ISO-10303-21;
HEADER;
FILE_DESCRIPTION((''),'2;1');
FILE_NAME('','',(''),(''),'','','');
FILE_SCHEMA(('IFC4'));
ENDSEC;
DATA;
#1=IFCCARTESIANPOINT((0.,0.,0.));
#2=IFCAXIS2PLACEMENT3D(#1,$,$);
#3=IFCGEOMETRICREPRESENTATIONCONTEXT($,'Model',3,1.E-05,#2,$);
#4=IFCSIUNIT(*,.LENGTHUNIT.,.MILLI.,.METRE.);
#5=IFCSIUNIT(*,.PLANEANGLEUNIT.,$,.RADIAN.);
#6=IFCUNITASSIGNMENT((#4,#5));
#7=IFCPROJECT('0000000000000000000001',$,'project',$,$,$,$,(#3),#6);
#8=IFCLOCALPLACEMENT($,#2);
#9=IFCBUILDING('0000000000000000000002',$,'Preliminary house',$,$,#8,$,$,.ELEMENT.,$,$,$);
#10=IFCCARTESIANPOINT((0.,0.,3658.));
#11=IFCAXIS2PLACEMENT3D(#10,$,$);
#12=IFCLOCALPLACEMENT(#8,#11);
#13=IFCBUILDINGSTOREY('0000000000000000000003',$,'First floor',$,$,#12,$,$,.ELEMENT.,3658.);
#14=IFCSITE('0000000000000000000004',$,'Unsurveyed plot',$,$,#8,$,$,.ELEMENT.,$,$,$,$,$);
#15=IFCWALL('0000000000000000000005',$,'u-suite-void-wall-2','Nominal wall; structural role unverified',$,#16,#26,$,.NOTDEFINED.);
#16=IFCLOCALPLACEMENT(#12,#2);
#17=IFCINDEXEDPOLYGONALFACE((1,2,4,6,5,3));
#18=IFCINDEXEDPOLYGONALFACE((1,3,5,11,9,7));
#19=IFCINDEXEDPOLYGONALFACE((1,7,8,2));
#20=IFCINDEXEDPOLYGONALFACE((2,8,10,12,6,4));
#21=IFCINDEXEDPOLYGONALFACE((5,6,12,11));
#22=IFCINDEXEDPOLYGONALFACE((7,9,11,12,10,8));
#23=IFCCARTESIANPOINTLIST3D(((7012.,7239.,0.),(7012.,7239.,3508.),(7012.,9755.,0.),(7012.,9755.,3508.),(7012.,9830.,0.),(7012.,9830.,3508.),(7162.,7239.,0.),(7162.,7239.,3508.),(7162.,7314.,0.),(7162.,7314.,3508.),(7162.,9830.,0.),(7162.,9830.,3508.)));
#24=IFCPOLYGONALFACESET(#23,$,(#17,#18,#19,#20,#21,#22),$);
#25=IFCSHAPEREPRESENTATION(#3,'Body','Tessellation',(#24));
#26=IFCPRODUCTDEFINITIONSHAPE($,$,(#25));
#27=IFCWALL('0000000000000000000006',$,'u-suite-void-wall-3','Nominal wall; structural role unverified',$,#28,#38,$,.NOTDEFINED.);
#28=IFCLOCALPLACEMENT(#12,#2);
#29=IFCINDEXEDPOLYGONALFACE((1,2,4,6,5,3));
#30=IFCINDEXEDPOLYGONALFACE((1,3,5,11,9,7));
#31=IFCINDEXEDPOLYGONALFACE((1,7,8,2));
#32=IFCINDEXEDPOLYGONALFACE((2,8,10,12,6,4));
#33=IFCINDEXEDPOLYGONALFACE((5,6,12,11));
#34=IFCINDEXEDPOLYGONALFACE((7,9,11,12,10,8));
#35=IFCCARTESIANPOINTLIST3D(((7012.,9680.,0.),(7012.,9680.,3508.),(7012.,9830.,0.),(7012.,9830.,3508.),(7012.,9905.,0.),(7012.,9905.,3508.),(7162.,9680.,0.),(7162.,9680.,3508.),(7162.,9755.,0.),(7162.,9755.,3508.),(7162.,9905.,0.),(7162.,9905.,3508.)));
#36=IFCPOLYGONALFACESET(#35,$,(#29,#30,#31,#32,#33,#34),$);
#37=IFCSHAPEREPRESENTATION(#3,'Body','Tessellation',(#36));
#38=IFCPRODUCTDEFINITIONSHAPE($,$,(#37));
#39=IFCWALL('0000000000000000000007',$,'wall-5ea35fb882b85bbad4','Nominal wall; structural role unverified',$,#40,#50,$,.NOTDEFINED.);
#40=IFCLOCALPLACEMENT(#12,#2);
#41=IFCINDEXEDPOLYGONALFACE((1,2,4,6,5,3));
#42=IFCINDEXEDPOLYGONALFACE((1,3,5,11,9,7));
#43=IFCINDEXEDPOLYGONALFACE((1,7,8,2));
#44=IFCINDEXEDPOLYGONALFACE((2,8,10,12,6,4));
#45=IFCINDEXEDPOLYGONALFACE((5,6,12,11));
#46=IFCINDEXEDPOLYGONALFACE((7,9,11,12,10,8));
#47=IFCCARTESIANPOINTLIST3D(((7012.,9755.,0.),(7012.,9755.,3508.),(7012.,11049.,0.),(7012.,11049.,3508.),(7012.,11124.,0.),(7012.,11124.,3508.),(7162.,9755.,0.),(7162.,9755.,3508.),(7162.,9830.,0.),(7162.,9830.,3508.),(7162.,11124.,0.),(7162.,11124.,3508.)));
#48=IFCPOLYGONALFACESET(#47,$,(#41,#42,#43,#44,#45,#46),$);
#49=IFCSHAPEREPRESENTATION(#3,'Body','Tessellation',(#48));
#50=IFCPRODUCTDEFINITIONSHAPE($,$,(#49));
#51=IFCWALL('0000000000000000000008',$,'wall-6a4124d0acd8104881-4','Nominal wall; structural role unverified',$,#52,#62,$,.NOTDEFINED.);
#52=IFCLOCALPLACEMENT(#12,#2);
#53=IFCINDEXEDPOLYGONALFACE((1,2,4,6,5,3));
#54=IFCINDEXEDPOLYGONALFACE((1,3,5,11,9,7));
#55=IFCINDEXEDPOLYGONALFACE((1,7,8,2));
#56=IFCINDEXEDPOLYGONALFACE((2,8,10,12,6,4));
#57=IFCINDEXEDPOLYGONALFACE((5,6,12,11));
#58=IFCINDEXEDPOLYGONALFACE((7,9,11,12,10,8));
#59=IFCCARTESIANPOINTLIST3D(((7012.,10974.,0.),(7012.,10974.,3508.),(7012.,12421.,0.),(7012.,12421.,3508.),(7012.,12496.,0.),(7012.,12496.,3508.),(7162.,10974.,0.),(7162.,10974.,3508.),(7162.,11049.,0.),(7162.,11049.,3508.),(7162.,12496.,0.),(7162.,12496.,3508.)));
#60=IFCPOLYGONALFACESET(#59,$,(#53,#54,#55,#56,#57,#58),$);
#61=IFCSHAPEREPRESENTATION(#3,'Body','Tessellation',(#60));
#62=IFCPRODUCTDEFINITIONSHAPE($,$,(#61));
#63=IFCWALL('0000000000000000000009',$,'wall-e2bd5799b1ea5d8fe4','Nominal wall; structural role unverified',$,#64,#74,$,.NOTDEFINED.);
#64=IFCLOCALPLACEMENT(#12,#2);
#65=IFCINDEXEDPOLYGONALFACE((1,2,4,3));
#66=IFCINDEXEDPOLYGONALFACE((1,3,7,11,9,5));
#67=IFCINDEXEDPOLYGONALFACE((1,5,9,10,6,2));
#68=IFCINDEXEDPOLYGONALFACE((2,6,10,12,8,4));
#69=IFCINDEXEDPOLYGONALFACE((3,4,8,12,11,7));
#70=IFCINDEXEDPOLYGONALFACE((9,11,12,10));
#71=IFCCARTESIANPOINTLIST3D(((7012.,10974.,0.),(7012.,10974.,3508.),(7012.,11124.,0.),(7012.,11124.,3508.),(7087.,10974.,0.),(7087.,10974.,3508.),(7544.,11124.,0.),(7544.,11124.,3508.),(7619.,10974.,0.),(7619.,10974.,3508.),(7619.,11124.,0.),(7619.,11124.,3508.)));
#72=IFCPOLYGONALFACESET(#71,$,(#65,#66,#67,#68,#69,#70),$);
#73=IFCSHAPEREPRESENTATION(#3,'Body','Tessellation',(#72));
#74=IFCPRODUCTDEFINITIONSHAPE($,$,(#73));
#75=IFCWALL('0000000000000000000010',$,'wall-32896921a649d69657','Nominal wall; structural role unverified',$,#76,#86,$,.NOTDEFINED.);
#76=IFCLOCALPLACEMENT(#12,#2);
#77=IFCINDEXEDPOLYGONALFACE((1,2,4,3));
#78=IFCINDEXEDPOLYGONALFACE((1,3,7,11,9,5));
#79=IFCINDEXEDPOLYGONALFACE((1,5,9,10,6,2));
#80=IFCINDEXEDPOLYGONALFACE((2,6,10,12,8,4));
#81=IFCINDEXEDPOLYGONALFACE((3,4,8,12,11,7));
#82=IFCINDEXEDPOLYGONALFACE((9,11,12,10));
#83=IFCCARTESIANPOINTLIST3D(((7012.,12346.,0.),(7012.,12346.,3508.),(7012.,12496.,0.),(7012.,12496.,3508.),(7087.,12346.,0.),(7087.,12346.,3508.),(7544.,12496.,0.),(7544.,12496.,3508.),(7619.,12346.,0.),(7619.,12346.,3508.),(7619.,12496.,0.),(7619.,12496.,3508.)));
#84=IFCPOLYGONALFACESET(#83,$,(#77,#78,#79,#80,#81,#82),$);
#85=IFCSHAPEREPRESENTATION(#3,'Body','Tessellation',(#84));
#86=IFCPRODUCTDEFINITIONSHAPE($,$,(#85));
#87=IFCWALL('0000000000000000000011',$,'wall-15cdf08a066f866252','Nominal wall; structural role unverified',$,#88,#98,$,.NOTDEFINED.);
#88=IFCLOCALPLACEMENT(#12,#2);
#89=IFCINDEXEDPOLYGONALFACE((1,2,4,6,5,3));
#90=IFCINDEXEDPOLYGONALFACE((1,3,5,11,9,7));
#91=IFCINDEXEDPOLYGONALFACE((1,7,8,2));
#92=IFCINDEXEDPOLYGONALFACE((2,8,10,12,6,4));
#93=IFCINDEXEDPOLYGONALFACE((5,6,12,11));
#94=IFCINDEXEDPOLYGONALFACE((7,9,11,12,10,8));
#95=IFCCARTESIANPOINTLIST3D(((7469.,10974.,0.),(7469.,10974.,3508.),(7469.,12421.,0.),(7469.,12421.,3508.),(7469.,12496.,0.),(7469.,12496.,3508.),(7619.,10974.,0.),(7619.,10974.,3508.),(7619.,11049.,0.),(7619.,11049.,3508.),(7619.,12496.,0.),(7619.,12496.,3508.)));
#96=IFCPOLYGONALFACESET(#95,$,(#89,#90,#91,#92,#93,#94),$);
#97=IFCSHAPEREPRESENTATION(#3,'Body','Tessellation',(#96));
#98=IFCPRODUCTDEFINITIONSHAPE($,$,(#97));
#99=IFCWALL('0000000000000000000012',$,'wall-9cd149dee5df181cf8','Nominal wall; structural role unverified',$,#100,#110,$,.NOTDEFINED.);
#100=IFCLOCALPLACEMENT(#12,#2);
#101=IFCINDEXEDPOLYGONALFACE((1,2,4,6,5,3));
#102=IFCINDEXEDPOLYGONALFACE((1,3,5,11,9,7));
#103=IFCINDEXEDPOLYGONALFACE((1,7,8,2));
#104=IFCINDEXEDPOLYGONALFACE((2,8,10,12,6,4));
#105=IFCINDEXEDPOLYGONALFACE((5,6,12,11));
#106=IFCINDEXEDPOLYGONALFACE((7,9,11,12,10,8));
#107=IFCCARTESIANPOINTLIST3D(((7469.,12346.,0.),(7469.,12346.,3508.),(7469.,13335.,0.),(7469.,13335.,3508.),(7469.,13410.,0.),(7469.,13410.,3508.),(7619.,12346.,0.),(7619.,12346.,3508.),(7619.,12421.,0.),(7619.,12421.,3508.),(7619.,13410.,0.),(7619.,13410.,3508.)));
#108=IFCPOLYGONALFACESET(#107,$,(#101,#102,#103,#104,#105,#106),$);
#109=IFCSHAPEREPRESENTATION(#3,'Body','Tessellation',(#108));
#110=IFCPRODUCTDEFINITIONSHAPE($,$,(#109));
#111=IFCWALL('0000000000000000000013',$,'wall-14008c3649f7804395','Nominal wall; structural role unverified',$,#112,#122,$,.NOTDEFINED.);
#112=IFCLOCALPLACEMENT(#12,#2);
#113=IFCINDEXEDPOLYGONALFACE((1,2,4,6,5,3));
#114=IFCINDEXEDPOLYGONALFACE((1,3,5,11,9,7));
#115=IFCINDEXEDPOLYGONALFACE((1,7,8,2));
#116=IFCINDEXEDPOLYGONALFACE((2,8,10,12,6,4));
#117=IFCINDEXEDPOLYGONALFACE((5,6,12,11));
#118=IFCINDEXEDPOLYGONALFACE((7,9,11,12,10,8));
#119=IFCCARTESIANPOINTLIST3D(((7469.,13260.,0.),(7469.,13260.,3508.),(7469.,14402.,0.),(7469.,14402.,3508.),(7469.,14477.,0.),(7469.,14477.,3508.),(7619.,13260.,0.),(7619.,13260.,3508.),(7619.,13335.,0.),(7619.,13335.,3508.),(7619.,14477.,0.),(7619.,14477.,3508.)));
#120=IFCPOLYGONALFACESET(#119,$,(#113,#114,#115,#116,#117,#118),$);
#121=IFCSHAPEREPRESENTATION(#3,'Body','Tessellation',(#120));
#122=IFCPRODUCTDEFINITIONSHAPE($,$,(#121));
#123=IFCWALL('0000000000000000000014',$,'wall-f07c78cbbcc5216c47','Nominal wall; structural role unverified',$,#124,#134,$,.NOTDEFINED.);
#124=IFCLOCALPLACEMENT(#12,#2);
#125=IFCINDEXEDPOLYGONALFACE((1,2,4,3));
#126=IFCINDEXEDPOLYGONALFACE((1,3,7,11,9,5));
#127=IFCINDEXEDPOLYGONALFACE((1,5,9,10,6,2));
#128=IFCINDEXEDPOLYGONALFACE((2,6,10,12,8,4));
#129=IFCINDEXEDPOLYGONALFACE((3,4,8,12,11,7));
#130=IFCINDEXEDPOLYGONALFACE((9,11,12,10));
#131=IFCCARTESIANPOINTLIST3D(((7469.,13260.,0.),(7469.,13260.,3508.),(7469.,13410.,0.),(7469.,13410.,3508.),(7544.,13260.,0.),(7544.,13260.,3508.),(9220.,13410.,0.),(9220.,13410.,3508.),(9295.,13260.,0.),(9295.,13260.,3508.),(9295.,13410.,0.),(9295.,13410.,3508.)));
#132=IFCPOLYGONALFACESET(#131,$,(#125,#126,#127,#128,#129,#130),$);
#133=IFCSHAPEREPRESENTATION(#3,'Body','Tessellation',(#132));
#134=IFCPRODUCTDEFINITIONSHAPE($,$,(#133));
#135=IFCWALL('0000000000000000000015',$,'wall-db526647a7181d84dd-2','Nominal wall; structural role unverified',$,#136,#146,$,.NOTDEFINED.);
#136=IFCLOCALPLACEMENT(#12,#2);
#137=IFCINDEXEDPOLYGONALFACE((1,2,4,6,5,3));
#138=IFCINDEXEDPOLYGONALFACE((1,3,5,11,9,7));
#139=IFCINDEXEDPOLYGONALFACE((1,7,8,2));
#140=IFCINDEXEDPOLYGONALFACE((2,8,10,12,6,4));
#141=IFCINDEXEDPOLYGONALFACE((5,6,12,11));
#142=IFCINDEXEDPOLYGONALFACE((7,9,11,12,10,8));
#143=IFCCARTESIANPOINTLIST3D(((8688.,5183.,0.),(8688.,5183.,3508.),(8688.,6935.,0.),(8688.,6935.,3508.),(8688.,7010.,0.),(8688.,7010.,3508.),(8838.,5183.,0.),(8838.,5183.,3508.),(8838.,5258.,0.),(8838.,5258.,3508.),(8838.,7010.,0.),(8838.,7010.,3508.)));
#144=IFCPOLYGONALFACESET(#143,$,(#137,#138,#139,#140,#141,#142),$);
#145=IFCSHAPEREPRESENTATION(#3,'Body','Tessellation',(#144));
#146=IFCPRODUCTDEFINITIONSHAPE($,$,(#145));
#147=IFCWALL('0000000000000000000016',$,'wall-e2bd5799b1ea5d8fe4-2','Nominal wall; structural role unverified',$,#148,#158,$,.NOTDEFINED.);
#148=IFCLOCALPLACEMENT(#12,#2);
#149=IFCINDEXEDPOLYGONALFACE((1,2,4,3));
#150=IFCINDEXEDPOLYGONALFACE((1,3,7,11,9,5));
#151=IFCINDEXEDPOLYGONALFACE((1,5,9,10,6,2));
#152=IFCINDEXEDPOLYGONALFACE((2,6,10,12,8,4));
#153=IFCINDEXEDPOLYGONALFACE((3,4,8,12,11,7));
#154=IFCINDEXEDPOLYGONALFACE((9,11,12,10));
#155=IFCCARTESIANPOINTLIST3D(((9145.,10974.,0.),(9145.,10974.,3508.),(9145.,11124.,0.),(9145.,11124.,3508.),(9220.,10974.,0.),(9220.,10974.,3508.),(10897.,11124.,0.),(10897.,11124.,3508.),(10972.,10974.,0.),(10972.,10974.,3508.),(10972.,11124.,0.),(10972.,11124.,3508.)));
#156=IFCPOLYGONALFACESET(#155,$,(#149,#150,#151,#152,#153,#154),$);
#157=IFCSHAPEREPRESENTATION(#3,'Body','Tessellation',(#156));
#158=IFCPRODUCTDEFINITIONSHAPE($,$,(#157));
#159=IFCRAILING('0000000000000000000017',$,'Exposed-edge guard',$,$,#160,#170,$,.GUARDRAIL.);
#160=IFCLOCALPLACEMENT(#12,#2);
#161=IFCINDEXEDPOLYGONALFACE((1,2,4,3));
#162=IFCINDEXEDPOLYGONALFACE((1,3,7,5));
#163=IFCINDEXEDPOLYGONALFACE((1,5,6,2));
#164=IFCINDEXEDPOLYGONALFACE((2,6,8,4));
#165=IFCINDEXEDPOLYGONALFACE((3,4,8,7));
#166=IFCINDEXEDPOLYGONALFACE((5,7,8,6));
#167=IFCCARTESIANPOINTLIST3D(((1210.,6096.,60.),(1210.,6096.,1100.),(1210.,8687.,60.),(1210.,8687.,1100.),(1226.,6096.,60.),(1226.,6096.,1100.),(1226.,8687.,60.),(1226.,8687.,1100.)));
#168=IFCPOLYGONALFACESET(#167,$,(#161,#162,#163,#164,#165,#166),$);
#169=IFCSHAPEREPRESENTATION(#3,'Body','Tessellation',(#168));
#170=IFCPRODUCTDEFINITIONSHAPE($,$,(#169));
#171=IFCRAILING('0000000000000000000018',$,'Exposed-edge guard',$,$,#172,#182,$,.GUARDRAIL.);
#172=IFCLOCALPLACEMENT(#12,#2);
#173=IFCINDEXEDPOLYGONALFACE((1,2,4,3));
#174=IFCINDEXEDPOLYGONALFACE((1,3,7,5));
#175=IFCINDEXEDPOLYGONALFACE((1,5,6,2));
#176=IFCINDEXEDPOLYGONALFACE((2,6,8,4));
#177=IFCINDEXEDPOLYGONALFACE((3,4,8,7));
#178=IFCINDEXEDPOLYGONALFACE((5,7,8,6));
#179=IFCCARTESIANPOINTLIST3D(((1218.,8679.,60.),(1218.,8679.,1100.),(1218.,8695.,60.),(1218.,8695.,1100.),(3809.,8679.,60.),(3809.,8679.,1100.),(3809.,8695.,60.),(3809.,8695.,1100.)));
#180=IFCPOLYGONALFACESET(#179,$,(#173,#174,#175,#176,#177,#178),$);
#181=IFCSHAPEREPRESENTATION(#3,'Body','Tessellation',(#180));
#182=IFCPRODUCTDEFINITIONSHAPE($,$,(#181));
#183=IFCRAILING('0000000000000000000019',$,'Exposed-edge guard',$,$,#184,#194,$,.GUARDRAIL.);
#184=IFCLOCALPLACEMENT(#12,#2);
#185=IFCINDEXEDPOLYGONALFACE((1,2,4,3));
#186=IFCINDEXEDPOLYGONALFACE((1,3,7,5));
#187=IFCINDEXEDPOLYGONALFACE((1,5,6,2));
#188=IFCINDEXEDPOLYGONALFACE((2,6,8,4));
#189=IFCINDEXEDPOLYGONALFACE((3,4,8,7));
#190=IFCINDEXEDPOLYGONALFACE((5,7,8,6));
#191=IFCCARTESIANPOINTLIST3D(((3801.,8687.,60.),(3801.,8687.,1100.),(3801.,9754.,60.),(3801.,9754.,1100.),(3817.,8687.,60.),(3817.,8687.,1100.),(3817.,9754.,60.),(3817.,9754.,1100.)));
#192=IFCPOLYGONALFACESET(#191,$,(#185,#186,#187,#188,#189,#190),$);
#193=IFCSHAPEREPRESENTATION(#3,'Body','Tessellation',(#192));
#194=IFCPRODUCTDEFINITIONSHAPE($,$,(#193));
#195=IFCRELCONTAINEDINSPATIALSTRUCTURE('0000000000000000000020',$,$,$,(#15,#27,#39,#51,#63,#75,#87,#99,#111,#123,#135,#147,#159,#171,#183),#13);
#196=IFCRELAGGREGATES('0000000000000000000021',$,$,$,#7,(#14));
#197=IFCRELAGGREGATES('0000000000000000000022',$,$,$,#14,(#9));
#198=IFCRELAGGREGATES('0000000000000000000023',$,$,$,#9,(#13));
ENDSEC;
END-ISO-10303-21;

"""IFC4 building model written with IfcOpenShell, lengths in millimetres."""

from ifc_helpers import new_model, si_unit, frame, origin, place, context, project, spatial, polyline, outline, extrude, element, save


model = new_model("IFC4")

# Units and contexts
model_context = context("Model", 3, precision=1e-05, world=origin())
ifc_project = project(units=[si_unit("LENGTHUNIT", "METRE", prefix="MILLI"), si_unit("PLANEANGLEUNIT", "RADIAN")], contexts=[model_context])

# Site, building, storey
placement_1 = place(None, origin())
site = spatial("IfcSite", under=ifc_project, at=placement_1, Name="Unsurveyed plot", CompositionType="ELEMENT")
building = spatial("IfcBuilding", under=site, at=placement_1, Name="Preliminary house", CompositionType="ELEMENT")
placement_2 = place(placement_1, frame((0.0, 0.0, 3658.0)))
storey = spatial("IfcBuildingStorey", under=building, at=placement_2, Name="First floor", CompositionType="ELEMENT", Elevation=3658.0)

# Walls
element("IfcWall", 1, at=placement_2, inside=storey, Name="u-suite-void-wall-2", Description="Nominal wall; structural role unverified", PredefinedType="NOTDEFINED", context=model_context, shape_type="SweptSolid", body=[
    extrude(outline(polyline([(7012.0, 9755.0), (7012.0, 9830.0), (7162.0, 9830.0), (7162.0, 7314.0), (7162.0, 7239.0), (7012.0, 7239.0), (7012.0, 9755.0)])), origin(), (0.0, 0.0, 1.0), 3508.0),
])
element("IfcWall", 2, at=placement_2, inside=storey, Name="u-suite-void-wall-3", Description="Nominal wall; structural role unverified", PredefinedType="NOTDEFINED", context=model_context, shape_type="SweptSolid", body=[
    extrude(outline(polyline([(7012.0, 9830.0), (7012.0, 9905.0), (7162.0, 9905.0), (7162.0, 9755.0), (7162.0, 9680.0), (7012.0, 9680.0), (7012.0, 9830.0)])), origin(), (0.0, 0.0, 1.0), 3508.0),
])
element("IfcWall", 3, at=placement_2, inside=storey, Name="wall-5ea35fb882b85bbad4", Description="Nominal wall; structural role unverified", PredefinedType="NOTDEFINED", context=model_context, shape_type="SweptSolid", body=[
    extrude(outline(polyline([(7012.0, 11049.0), (7012.0, 11124.0), (7162.0, 11124.0), (7162.0, 9830.0), (7162.0, 9755.0), (7012.0, 9755.0), (7012.0, 11049.0)])), origin(), (0.0, 0.0, 1.0), 3508.0),
])
element("IfcWall", 4, at=placement_2, inside=storey, Name="wall-6a4124d0acd8104881-4", Description="Nominal wall; structural role unverified", PredefinedType="NOTDEFINED", context=model_context, shape_type="SweptSolid", body=[
    extrude(outline(polyline([(7012.0, 12421.0), (7012.0, 12496.0), (7162.0, 12496.0), (7162.0, 11049.0), (7162.0, 10974.0), (7012.0, 10974.0), (7012.0, 12421.0)])), origin(), (0.0, 0.0, 1.0), 3508.0),
])
element("IfcWall", 5, at=placement_2, inside=storey, Name="wall-e2bd5799b1ea5d8fe4", Description="Nominal wall; structural role unverified", PredefinedType="NOTDEFINED", context=model_context, shape_type="SweptSolid", body=[
    extrude(outline(polyline([(7544.0, 11124.0), (7619.0, 11124.0), (7619.0, 10974.0), (7087.0, 10974.0), (7012.0, 10974.0), (7012.0, 11124.0), (7544.0, 11124.0)])), origin(), (0.0, 0.0, 1.0), 3508.0),
])
element("IfcWall", 6, at=placement_2, inside=storey, Name="wall-32896921a649d69657", Description="Nominal wall; structural role unverified", PredefinedType="NOTDEFINED", context=model_context, shape_type="SweptSolid", body=[
    extrude(outline(polyline([(7544.0, 12496.0), (7619.0, 12496.0), (7619.0, 12346.0), (7087.0, 12346.0), (7012.0, 12346.0), (7012.0, 12496.0), (7544.0, 12496.0)])), origin(), (0.0, 0.0, 1.0), 3508.0),
])
element("IfcWall", 7, at=placement_2, inside=storey, Name="wall-15cdf08a066f866252", Description="Nominal wall; structural role unverified", PredefinedType="NOTDEFINED", context=model_context, shape_type="SweptSolid", body=[
    extrude(outline(polyline([(7469.0, 12421.0), (7469.0, 12496.0), (7619.0, 12496.0), (7619.0, 11049.0), (7619.0, 10974.0), (7469.0, 10974.0), (7469.0, 12421.0)])), origin(), (0.0, 0.0, 1.0), 3508.0),
])

# Walls
element("IfcWall", 8, at=placement_2, inside=storey, Name="wall-9cd149dee5df181cf8", Description="Nominal wall; structural role unverified", PredefinedType="NOTDEFINED", context=model_context, shape_type="SweptSolid", body=[
    extrude(outline(polyline([(7469.0, 13335.0), (7469.0, 13410.0), (7619.0, 13410.0), (7619.0, 12421.0), (7619.0, 12346.0), (7469.0, 12346.0), (7469.0, 13335.0)])), origin(), (0.0, 0.0, 1.0), 3508.0),
])
element("IfcWall", 9, at=placement_2, inside=storey, Name="wall-14008c3649f7804395", Description="Nominal wall; structural role unverified", PredefinedType="NOTDEFINED", context=model_context, shape_type="SweptSolid", body=[
    extrude(outline(polyline([(7469.0, 14402.0), (7469.0, 14477.0), (7619.0, 14477.0), (7619.0, 13335.0), (7619.0, 13260.0), (7469.0, 13260.0), (7469.0, 14402.0)])), origin(), (0.0, 0.0, 1.0), 3508.0),
])
element("IfcWall", 10, at=placement_2, inside=storey, Name="wall-f07c78cbbcc5216c47", Description="Nominal wall; structural role unverified", PredefinedType="NOTDEFINED", context=model_context, shape_type="SweptSolid", body=[
    extrude(outline(polyline([(9220.0, 13410.0), (9295.0, 13410.0), (9295.0, 13260.0), (7544.0, 13260.0), (7469.0, 13260.0), (7469.0, 13410.0), (9220.0, 13410.0)])), origin(), (0.0, 0.0, 1.0), 3508.0),
])
element("IfcWall", 11, at=placement_2, inside=storey, Name="wall-db526647a7181d84dd-2", Description="Nominal wall; structural role unverified", PredefinedType="NOTDEFINED", context=model_context, shape_type="SweptSolid", body=[
    extrude(outline(polyline([(8688.0, 6935.0), (8688.0, 7010.0), (8838.0, 7010.0), (8838.0, 5258.0), (8838.0, 5183.0), (8688.0, 5183.0), (8688.0, 6935.0)])), origin(), (0.0, 0.0, 1.0), 3508.0),
])

# Wall
element("IfcWall", 12, at=placement_2, inside=storey, Name="wall-e2bd5799b1ea5d8fe4-2", Description="Nominal wall; structural role unverified", PredefinedType="NOTDEFINED", context=model_context, shape_type="SweptSolid", body=[
    extrude(outline(polyline([(10897.0, 11124.0), (10972.0, 11124.0), (10972.0, 10974.0), (9220.0, 10974.0), (9145.0, 10974.0), (9145.0, 11124.0), (10897.0, 11124.0)])), origin(), (0.0, 0.0, 1.0), 3508.0),
])

# Railings
element("IfcRailing", 13, at=placement_2, inside=storey, Name="Exposed-edge guard", PredefinedType="GUARDRAIL", context=model_context, shape_type="SweptSolid", body=[
    extrude(outline(polyline([(1210.0, 8687.0), (1226.0, 8687.0), (1226.0, 6096.0), (1210.0, 6096.0), (1210.0, 8687.0)])), frame((0.0, 0.0, 60.0)), (0.0, 0.0, 1.0), 1040.0),
])
element("IfcRailing", 14, at=placement_2, inside=storey, Name="Exposed-edge guard", PredefinedType="GUARDRAIL", context=model_context, shape_type="SweptSolid", body=[
    extrude(outline(polyline([(3809.0, 8695.0), (3809.0, 8679.0), (1218.0, 8679.0), (1218.0, 8695.0), (3809.0, 8695.0)])), frame((0.0, 0.0, 60.0)), (0.0, 0.0, 1.0), 1040.0),
])
element("IfcRailing", 15, at=placement_2, inside=storey, Name="Exposed-edge guard", PredefinedType="GUARDRAIL", context=model_context, shape_type="SweptSolid", body=[
    extrude(outline(polyline([(3801.0, 9754.0), (3817.0, 9754.0), (3817.0, 8687.0), (3801.0, 8687.0), (3801.0, 9754.0)])), frame((0.0, 0.0, 60.0)), (0.0, 0.0, 1.0), 1040.0),
])

save(model, "model.ifc")
